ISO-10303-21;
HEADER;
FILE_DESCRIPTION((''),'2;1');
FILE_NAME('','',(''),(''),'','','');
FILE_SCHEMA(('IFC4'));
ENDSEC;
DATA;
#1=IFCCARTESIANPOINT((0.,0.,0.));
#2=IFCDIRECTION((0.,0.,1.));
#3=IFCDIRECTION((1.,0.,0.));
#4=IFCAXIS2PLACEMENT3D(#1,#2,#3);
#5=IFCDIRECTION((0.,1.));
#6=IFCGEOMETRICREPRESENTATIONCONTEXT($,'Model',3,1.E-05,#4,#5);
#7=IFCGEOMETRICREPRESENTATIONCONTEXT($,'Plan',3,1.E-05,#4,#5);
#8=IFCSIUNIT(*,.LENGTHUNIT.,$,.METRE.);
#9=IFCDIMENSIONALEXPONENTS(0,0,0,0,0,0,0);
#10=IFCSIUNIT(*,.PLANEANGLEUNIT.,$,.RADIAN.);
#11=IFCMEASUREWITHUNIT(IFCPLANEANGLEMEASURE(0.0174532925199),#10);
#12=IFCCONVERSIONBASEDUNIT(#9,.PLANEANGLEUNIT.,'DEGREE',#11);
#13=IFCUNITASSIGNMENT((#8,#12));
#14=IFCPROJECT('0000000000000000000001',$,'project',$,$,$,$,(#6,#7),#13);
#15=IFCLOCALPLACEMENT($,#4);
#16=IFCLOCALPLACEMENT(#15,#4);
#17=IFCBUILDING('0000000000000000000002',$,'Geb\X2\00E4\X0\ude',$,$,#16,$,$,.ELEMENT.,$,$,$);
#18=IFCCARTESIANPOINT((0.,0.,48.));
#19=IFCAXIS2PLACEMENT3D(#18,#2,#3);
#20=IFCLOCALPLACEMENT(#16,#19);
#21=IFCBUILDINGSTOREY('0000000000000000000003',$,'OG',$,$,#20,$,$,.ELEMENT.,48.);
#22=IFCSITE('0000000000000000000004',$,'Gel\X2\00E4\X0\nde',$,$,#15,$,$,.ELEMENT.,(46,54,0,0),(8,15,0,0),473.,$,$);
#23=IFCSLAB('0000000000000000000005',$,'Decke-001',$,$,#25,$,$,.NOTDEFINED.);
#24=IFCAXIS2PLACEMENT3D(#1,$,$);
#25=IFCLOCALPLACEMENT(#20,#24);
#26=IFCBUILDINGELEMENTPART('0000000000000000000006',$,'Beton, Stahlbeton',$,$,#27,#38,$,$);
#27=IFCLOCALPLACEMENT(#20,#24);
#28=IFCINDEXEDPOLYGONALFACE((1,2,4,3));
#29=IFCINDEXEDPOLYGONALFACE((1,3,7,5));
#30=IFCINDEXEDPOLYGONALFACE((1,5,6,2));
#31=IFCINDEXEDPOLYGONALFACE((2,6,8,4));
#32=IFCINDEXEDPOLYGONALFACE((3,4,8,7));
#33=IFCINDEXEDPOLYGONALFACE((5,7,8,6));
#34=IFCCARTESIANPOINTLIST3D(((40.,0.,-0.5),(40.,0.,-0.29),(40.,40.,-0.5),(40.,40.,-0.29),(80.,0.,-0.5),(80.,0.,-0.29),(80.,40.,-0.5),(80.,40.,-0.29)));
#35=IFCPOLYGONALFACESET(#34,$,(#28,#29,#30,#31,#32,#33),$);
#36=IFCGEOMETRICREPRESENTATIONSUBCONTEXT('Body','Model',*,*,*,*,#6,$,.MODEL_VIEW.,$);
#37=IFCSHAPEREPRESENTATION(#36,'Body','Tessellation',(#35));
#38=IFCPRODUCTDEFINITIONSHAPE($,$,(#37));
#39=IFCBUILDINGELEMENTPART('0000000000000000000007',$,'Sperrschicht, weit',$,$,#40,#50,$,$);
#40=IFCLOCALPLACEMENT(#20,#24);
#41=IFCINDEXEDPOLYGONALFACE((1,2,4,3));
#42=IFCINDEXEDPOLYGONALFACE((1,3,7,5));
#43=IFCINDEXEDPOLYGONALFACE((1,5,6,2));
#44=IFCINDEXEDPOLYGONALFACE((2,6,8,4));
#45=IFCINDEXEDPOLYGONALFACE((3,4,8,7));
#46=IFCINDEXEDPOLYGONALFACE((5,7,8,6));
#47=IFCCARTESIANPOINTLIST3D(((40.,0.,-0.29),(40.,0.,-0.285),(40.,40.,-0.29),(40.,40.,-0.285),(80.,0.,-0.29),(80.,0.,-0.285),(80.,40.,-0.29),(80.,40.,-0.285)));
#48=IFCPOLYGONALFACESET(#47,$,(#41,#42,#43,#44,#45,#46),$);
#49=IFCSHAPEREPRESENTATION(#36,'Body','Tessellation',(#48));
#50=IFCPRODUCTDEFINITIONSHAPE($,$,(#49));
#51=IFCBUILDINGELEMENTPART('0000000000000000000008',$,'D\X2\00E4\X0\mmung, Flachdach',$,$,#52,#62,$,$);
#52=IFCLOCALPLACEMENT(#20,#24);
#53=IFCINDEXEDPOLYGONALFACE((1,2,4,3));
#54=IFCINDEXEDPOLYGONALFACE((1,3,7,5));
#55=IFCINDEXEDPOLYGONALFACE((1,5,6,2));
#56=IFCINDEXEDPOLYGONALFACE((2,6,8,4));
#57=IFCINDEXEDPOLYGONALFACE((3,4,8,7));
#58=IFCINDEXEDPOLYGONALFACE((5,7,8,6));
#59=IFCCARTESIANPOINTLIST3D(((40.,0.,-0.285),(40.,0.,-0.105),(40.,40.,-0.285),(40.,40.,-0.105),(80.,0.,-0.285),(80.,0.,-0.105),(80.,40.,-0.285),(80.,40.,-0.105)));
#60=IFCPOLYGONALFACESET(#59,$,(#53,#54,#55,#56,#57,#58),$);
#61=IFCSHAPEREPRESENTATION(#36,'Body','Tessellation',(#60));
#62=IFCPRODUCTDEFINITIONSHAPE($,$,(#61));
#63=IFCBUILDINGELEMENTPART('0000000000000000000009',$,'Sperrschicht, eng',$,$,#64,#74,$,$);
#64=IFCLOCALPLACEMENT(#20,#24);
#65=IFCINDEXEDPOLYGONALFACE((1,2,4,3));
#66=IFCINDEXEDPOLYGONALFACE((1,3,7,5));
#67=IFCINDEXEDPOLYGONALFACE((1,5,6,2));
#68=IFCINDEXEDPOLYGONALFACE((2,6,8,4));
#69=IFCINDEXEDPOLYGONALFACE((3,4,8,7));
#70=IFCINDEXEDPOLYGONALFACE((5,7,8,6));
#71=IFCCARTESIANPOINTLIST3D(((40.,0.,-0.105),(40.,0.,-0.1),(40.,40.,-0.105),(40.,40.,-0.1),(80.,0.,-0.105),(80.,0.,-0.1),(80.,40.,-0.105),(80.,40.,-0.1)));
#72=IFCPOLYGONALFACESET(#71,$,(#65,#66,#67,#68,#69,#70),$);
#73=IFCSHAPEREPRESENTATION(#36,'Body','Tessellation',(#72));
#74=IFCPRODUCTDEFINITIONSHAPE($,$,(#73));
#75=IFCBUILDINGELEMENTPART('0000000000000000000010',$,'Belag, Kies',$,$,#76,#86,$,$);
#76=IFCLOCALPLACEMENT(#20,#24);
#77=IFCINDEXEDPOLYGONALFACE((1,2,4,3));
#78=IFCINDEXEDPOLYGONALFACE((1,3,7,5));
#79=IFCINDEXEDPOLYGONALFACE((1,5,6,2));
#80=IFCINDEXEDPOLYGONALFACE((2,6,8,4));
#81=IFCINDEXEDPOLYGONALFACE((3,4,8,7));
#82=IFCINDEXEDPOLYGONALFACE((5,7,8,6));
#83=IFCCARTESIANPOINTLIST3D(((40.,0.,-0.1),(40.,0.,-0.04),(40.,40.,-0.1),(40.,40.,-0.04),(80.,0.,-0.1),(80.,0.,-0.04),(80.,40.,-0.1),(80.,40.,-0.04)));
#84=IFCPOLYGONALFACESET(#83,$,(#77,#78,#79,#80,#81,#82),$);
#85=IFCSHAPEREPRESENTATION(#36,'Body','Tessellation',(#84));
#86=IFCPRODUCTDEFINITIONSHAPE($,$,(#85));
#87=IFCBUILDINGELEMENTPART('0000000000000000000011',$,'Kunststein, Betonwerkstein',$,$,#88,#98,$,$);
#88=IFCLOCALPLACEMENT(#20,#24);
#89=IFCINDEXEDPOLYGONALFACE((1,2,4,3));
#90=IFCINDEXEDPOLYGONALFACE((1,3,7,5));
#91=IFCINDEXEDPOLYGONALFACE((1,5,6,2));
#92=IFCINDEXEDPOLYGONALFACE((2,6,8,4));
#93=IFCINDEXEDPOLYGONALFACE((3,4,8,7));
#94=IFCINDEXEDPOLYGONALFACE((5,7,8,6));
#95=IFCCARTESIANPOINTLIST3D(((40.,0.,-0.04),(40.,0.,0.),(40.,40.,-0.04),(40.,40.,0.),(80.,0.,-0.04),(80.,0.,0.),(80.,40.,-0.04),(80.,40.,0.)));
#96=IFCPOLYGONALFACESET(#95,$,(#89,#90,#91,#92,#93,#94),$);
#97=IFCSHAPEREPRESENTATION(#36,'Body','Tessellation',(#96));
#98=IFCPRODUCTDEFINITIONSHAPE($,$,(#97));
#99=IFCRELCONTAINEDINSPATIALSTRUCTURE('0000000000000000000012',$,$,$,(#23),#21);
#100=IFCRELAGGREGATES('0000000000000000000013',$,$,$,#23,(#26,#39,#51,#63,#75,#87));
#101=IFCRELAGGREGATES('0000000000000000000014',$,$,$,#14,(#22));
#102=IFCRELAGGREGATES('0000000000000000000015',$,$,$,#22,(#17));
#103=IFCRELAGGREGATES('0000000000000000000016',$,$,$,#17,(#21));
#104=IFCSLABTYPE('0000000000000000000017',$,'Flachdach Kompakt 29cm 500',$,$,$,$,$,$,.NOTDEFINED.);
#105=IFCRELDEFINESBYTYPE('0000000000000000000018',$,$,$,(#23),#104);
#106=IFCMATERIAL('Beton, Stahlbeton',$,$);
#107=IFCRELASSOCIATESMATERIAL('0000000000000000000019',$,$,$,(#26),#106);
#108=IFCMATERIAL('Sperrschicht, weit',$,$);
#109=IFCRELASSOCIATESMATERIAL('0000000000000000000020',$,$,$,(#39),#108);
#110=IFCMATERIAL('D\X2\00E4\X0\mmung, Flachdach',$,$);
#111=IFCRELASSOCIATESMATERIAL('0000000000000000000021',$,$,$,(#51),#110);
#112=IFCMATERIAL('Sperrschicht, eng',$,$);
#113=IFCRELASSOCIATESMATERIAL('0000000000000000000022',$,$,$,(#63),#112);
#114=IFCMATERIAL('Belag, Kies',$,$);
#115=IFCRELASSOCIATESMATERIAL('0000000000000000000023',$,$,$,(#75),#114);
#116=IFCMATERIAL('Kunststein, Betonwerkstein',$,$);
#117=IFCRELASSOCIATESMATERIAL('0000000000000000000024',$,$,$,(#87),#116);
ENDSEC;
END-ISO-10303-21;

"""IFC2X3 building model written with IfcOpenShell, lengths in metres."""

from ifc_helpers import new_model, entity, si_unit, converted_unit, direction, frame, origin_with_axes, place, context, subcontext, project, spatial, polyline, outline, extrude, material, type_object, element, aggregate, save


model = new_model("IFC2X3")

# Units and contexts
model_context = context("Model", 3, precision=1e-05, world=origin_with_axes(), true_north=direction((0.0, 1.0)))
plan_context = context("Plan", 3, precision=1e-05, world=origin_with_axes(), true_north=direction((0.0, 1.0)))
body_context = subcontext(model_context, "Body", "Model", "MODEL_VIEW")
ifc_project = project(units=[si_unit("LENGTHUNIT", "METRE"), converted_unit("PLANEANGLEUNIT", "DEGREE", entity("IfcPlaneAngleMeasure", 0.0174532925199), si_unit("PLANEANGLEUNIT", "RADIAN"), dimensions=[0, 0, 0, 0, 0, 0, 0])], contexts=[model_context, plan_context])

# Site, building, storey
site_placement = place(None, origin_with_axes())
site = spatial("IfcSite", under=ifc_project, at=site_placement, Name="Gelände", CompositionType="ELEMENT", RefLatitude=(46, 54, 0, 0), RefLongitude=(8, 15, 0, 0), RefElevation=473.0)
building_placement = place(site_placement, origin_with_axes())
building = spatial("IfcBuilding", under=site, at=building_placement, Name="Gebäude", CompositionType="ELEMENT")
storey_placement = place(building_placement, frame((0.0, 0.0, 48.0), z_axis=(0.0, 0.0, 1.0), x_axis=(1.0, 0.0, 0.0)))
storey = spatial("IfcBuildingStorey", under=building, at=storey_placement, Name="OG", CompositionType="ELEMENT", Elevation=48.0)

# Slab, building element parts
slab_type = type_object("IfcSlabType", Name="Flachdach Kompakt 29cm 500", PredefinedType="NOTDEFINED")
slab_placement = place(storey_placement, frame((40.0, 0.0, 0.0), z_axis=(0.0, 0.0, 1.0), x_axis=(1.0, 0.0, 0.0)))
slab = element("IfcSlab", 1, at=slab_placement, inside=storey, type_object=slab_type, Name="Decke-001", PredefinedType="NOTDEFINED")
ifc_material_1 = material(Name="Beton, Stahlbeton")
building_element_part_1_placement = place(slab_placement, origin_with_axes())
building_element_part_1 = element("IfcBuildingElementPart", 2, at=building_element_part_1_placement, material=ifc_material_1, Name="Beton, Stahlbeton", context=body_context, shape_type="SweptSolid", body=[
    extrude(outline(polyline([(0.0, 0.0), (40.0, 0.0), (40.0, 40.0), (0.0, 40.0), (0.0, 0.0)])), frame((0.0, 0.0, -0.5), z_axis=(0.0, 0.0, 1.0), x_axis=(1.0, 0.0, 0.0)), (0.0, 0.0, 1.0), 0.21),
])
ifc_material_2 = material(Name="Sperrschicht, weit")
building_element_part_2_placement = place(slab_placement, origin_with_axes())
building_element_part_2 = element("IfcBuildingElementPart", 3, at=building_element_part_2_placement, material=ifc_material_2, Name="Sperrschicht, weit", context=body_context, shape_type="SweptSolid", body=[
    extrude(outline(polyline([(0.0, 0.0), (40.0, 0.0), (40.0, 40.0), (0.0, 40.0), (0.0, 0.0)])), frame((0.0, 0.0, -0.29), z_axis=(0.0, 0.0, 1.0), x_axis=(1.0, 0.0, 0.0)), (0.0, 0.0, 1.0), 0.005),
])
ifc_material_3 = material(Name="Dämmung, Flachdach")
building_element_part_3_placement = place(slab_placement, origin_with_axes())
building_element_part_3 = element("IfcBuildingElementPart", 4, at=building_element_part_3_placement, material=ifc_material_3, Name="Dämmung, Flachdach", context=body_context, shape_type="SweptSolid", body=[
    extrude(outline(polyline([(0.0, 0.0), (40.0, 0.0), (40.0, 40.0), (0.0, 40.0), (0.0, 0.0)])), frame((0.0, 0.0, -0.285), z_axis=(0.0, 0.0, 1.0), x_axis=(1.0, 0.0, 0.0)), (0.0, 0.0, 1.0), 0.18),
])
ifc_material_4 = material(Name="Sperrschicht, eng")
building_element_part_4_placement = place(slab_placement, origin_with_axes())
building_element_part_4 = element("IfcBuildingElementPart", 5, at=building_element_part_4_placement, material=ifc_material_4, Name="Sperrschicht, eng", context=body_context, shape_type="SweptSolid", body=[
    extrude(outline(polyline([(0.0, 0.0), (40.0, 0.0), (40.0, 40.0), (0.0, 40.0), (0.0, 0.0)])), frame((0.0, 0.0, -0.105), z_axis=(0.0, 0.0, 1.0), x_axis=(1.0, 0.0, 0.0)), (0.0, 0.0, 1.0), 0.005),
])
ifc_material_5 = material(Name="Belag, Kies")
building_element_part_5_placement = place(slab_placement, origin_with_axes())
building_element_part_5 = element("IfcBuildingElementPart", 6, at=building_element_part_5_placement, material=ifc_material_5, Name="Belag, Kies", context=body_context, shape_type="SweptSolid", body=[
    extrude(outline(polyline([(0.0, 0.0), (40.0, 0.0), (40.0, 40.0), (0.0, 40.0), (0.0, 0.0)])), frame((0.0, 0.0, -0.1), z_axis=(0.0, 0.0, 1.0), x_axis=(1.0, 0.0, 0.0)), (0.0, 0.0, 1.0), 0.06),
])
ifc_material_6 = material(Name="Kunststein, Betonwerkstein")
building_element_part_6_placement = place(slab_placement, origin_with_axes())
building_element_part_6 = element("IfcBuildingElementPart", 7, at=building_element_part_6_placement, material=ifc_material_6, Name="Kunststein, Betonwerkstein", context=body_context, shape_type="SweptSolid", body=[
    extrude(outline(polyline([(0.0, 0.0), (40.0, 0.0), (40.0, 40.0), (0.0, 40.0), (0.0, 0.0)])), frame((0.0, 0.0, -0.04), z_axis=(0.0, 0.0, 1.0), x_axis=(1.0, 0.0, 0.0)), (0.0, 0.0, 1.0), 0.04),
])
aggregate(slab, [building_element_part_1, building_element_part_2, building_element_part_3, building_element_part_4, building_element_part_5, building_element_part_6])

save(model, "model.ifc")
